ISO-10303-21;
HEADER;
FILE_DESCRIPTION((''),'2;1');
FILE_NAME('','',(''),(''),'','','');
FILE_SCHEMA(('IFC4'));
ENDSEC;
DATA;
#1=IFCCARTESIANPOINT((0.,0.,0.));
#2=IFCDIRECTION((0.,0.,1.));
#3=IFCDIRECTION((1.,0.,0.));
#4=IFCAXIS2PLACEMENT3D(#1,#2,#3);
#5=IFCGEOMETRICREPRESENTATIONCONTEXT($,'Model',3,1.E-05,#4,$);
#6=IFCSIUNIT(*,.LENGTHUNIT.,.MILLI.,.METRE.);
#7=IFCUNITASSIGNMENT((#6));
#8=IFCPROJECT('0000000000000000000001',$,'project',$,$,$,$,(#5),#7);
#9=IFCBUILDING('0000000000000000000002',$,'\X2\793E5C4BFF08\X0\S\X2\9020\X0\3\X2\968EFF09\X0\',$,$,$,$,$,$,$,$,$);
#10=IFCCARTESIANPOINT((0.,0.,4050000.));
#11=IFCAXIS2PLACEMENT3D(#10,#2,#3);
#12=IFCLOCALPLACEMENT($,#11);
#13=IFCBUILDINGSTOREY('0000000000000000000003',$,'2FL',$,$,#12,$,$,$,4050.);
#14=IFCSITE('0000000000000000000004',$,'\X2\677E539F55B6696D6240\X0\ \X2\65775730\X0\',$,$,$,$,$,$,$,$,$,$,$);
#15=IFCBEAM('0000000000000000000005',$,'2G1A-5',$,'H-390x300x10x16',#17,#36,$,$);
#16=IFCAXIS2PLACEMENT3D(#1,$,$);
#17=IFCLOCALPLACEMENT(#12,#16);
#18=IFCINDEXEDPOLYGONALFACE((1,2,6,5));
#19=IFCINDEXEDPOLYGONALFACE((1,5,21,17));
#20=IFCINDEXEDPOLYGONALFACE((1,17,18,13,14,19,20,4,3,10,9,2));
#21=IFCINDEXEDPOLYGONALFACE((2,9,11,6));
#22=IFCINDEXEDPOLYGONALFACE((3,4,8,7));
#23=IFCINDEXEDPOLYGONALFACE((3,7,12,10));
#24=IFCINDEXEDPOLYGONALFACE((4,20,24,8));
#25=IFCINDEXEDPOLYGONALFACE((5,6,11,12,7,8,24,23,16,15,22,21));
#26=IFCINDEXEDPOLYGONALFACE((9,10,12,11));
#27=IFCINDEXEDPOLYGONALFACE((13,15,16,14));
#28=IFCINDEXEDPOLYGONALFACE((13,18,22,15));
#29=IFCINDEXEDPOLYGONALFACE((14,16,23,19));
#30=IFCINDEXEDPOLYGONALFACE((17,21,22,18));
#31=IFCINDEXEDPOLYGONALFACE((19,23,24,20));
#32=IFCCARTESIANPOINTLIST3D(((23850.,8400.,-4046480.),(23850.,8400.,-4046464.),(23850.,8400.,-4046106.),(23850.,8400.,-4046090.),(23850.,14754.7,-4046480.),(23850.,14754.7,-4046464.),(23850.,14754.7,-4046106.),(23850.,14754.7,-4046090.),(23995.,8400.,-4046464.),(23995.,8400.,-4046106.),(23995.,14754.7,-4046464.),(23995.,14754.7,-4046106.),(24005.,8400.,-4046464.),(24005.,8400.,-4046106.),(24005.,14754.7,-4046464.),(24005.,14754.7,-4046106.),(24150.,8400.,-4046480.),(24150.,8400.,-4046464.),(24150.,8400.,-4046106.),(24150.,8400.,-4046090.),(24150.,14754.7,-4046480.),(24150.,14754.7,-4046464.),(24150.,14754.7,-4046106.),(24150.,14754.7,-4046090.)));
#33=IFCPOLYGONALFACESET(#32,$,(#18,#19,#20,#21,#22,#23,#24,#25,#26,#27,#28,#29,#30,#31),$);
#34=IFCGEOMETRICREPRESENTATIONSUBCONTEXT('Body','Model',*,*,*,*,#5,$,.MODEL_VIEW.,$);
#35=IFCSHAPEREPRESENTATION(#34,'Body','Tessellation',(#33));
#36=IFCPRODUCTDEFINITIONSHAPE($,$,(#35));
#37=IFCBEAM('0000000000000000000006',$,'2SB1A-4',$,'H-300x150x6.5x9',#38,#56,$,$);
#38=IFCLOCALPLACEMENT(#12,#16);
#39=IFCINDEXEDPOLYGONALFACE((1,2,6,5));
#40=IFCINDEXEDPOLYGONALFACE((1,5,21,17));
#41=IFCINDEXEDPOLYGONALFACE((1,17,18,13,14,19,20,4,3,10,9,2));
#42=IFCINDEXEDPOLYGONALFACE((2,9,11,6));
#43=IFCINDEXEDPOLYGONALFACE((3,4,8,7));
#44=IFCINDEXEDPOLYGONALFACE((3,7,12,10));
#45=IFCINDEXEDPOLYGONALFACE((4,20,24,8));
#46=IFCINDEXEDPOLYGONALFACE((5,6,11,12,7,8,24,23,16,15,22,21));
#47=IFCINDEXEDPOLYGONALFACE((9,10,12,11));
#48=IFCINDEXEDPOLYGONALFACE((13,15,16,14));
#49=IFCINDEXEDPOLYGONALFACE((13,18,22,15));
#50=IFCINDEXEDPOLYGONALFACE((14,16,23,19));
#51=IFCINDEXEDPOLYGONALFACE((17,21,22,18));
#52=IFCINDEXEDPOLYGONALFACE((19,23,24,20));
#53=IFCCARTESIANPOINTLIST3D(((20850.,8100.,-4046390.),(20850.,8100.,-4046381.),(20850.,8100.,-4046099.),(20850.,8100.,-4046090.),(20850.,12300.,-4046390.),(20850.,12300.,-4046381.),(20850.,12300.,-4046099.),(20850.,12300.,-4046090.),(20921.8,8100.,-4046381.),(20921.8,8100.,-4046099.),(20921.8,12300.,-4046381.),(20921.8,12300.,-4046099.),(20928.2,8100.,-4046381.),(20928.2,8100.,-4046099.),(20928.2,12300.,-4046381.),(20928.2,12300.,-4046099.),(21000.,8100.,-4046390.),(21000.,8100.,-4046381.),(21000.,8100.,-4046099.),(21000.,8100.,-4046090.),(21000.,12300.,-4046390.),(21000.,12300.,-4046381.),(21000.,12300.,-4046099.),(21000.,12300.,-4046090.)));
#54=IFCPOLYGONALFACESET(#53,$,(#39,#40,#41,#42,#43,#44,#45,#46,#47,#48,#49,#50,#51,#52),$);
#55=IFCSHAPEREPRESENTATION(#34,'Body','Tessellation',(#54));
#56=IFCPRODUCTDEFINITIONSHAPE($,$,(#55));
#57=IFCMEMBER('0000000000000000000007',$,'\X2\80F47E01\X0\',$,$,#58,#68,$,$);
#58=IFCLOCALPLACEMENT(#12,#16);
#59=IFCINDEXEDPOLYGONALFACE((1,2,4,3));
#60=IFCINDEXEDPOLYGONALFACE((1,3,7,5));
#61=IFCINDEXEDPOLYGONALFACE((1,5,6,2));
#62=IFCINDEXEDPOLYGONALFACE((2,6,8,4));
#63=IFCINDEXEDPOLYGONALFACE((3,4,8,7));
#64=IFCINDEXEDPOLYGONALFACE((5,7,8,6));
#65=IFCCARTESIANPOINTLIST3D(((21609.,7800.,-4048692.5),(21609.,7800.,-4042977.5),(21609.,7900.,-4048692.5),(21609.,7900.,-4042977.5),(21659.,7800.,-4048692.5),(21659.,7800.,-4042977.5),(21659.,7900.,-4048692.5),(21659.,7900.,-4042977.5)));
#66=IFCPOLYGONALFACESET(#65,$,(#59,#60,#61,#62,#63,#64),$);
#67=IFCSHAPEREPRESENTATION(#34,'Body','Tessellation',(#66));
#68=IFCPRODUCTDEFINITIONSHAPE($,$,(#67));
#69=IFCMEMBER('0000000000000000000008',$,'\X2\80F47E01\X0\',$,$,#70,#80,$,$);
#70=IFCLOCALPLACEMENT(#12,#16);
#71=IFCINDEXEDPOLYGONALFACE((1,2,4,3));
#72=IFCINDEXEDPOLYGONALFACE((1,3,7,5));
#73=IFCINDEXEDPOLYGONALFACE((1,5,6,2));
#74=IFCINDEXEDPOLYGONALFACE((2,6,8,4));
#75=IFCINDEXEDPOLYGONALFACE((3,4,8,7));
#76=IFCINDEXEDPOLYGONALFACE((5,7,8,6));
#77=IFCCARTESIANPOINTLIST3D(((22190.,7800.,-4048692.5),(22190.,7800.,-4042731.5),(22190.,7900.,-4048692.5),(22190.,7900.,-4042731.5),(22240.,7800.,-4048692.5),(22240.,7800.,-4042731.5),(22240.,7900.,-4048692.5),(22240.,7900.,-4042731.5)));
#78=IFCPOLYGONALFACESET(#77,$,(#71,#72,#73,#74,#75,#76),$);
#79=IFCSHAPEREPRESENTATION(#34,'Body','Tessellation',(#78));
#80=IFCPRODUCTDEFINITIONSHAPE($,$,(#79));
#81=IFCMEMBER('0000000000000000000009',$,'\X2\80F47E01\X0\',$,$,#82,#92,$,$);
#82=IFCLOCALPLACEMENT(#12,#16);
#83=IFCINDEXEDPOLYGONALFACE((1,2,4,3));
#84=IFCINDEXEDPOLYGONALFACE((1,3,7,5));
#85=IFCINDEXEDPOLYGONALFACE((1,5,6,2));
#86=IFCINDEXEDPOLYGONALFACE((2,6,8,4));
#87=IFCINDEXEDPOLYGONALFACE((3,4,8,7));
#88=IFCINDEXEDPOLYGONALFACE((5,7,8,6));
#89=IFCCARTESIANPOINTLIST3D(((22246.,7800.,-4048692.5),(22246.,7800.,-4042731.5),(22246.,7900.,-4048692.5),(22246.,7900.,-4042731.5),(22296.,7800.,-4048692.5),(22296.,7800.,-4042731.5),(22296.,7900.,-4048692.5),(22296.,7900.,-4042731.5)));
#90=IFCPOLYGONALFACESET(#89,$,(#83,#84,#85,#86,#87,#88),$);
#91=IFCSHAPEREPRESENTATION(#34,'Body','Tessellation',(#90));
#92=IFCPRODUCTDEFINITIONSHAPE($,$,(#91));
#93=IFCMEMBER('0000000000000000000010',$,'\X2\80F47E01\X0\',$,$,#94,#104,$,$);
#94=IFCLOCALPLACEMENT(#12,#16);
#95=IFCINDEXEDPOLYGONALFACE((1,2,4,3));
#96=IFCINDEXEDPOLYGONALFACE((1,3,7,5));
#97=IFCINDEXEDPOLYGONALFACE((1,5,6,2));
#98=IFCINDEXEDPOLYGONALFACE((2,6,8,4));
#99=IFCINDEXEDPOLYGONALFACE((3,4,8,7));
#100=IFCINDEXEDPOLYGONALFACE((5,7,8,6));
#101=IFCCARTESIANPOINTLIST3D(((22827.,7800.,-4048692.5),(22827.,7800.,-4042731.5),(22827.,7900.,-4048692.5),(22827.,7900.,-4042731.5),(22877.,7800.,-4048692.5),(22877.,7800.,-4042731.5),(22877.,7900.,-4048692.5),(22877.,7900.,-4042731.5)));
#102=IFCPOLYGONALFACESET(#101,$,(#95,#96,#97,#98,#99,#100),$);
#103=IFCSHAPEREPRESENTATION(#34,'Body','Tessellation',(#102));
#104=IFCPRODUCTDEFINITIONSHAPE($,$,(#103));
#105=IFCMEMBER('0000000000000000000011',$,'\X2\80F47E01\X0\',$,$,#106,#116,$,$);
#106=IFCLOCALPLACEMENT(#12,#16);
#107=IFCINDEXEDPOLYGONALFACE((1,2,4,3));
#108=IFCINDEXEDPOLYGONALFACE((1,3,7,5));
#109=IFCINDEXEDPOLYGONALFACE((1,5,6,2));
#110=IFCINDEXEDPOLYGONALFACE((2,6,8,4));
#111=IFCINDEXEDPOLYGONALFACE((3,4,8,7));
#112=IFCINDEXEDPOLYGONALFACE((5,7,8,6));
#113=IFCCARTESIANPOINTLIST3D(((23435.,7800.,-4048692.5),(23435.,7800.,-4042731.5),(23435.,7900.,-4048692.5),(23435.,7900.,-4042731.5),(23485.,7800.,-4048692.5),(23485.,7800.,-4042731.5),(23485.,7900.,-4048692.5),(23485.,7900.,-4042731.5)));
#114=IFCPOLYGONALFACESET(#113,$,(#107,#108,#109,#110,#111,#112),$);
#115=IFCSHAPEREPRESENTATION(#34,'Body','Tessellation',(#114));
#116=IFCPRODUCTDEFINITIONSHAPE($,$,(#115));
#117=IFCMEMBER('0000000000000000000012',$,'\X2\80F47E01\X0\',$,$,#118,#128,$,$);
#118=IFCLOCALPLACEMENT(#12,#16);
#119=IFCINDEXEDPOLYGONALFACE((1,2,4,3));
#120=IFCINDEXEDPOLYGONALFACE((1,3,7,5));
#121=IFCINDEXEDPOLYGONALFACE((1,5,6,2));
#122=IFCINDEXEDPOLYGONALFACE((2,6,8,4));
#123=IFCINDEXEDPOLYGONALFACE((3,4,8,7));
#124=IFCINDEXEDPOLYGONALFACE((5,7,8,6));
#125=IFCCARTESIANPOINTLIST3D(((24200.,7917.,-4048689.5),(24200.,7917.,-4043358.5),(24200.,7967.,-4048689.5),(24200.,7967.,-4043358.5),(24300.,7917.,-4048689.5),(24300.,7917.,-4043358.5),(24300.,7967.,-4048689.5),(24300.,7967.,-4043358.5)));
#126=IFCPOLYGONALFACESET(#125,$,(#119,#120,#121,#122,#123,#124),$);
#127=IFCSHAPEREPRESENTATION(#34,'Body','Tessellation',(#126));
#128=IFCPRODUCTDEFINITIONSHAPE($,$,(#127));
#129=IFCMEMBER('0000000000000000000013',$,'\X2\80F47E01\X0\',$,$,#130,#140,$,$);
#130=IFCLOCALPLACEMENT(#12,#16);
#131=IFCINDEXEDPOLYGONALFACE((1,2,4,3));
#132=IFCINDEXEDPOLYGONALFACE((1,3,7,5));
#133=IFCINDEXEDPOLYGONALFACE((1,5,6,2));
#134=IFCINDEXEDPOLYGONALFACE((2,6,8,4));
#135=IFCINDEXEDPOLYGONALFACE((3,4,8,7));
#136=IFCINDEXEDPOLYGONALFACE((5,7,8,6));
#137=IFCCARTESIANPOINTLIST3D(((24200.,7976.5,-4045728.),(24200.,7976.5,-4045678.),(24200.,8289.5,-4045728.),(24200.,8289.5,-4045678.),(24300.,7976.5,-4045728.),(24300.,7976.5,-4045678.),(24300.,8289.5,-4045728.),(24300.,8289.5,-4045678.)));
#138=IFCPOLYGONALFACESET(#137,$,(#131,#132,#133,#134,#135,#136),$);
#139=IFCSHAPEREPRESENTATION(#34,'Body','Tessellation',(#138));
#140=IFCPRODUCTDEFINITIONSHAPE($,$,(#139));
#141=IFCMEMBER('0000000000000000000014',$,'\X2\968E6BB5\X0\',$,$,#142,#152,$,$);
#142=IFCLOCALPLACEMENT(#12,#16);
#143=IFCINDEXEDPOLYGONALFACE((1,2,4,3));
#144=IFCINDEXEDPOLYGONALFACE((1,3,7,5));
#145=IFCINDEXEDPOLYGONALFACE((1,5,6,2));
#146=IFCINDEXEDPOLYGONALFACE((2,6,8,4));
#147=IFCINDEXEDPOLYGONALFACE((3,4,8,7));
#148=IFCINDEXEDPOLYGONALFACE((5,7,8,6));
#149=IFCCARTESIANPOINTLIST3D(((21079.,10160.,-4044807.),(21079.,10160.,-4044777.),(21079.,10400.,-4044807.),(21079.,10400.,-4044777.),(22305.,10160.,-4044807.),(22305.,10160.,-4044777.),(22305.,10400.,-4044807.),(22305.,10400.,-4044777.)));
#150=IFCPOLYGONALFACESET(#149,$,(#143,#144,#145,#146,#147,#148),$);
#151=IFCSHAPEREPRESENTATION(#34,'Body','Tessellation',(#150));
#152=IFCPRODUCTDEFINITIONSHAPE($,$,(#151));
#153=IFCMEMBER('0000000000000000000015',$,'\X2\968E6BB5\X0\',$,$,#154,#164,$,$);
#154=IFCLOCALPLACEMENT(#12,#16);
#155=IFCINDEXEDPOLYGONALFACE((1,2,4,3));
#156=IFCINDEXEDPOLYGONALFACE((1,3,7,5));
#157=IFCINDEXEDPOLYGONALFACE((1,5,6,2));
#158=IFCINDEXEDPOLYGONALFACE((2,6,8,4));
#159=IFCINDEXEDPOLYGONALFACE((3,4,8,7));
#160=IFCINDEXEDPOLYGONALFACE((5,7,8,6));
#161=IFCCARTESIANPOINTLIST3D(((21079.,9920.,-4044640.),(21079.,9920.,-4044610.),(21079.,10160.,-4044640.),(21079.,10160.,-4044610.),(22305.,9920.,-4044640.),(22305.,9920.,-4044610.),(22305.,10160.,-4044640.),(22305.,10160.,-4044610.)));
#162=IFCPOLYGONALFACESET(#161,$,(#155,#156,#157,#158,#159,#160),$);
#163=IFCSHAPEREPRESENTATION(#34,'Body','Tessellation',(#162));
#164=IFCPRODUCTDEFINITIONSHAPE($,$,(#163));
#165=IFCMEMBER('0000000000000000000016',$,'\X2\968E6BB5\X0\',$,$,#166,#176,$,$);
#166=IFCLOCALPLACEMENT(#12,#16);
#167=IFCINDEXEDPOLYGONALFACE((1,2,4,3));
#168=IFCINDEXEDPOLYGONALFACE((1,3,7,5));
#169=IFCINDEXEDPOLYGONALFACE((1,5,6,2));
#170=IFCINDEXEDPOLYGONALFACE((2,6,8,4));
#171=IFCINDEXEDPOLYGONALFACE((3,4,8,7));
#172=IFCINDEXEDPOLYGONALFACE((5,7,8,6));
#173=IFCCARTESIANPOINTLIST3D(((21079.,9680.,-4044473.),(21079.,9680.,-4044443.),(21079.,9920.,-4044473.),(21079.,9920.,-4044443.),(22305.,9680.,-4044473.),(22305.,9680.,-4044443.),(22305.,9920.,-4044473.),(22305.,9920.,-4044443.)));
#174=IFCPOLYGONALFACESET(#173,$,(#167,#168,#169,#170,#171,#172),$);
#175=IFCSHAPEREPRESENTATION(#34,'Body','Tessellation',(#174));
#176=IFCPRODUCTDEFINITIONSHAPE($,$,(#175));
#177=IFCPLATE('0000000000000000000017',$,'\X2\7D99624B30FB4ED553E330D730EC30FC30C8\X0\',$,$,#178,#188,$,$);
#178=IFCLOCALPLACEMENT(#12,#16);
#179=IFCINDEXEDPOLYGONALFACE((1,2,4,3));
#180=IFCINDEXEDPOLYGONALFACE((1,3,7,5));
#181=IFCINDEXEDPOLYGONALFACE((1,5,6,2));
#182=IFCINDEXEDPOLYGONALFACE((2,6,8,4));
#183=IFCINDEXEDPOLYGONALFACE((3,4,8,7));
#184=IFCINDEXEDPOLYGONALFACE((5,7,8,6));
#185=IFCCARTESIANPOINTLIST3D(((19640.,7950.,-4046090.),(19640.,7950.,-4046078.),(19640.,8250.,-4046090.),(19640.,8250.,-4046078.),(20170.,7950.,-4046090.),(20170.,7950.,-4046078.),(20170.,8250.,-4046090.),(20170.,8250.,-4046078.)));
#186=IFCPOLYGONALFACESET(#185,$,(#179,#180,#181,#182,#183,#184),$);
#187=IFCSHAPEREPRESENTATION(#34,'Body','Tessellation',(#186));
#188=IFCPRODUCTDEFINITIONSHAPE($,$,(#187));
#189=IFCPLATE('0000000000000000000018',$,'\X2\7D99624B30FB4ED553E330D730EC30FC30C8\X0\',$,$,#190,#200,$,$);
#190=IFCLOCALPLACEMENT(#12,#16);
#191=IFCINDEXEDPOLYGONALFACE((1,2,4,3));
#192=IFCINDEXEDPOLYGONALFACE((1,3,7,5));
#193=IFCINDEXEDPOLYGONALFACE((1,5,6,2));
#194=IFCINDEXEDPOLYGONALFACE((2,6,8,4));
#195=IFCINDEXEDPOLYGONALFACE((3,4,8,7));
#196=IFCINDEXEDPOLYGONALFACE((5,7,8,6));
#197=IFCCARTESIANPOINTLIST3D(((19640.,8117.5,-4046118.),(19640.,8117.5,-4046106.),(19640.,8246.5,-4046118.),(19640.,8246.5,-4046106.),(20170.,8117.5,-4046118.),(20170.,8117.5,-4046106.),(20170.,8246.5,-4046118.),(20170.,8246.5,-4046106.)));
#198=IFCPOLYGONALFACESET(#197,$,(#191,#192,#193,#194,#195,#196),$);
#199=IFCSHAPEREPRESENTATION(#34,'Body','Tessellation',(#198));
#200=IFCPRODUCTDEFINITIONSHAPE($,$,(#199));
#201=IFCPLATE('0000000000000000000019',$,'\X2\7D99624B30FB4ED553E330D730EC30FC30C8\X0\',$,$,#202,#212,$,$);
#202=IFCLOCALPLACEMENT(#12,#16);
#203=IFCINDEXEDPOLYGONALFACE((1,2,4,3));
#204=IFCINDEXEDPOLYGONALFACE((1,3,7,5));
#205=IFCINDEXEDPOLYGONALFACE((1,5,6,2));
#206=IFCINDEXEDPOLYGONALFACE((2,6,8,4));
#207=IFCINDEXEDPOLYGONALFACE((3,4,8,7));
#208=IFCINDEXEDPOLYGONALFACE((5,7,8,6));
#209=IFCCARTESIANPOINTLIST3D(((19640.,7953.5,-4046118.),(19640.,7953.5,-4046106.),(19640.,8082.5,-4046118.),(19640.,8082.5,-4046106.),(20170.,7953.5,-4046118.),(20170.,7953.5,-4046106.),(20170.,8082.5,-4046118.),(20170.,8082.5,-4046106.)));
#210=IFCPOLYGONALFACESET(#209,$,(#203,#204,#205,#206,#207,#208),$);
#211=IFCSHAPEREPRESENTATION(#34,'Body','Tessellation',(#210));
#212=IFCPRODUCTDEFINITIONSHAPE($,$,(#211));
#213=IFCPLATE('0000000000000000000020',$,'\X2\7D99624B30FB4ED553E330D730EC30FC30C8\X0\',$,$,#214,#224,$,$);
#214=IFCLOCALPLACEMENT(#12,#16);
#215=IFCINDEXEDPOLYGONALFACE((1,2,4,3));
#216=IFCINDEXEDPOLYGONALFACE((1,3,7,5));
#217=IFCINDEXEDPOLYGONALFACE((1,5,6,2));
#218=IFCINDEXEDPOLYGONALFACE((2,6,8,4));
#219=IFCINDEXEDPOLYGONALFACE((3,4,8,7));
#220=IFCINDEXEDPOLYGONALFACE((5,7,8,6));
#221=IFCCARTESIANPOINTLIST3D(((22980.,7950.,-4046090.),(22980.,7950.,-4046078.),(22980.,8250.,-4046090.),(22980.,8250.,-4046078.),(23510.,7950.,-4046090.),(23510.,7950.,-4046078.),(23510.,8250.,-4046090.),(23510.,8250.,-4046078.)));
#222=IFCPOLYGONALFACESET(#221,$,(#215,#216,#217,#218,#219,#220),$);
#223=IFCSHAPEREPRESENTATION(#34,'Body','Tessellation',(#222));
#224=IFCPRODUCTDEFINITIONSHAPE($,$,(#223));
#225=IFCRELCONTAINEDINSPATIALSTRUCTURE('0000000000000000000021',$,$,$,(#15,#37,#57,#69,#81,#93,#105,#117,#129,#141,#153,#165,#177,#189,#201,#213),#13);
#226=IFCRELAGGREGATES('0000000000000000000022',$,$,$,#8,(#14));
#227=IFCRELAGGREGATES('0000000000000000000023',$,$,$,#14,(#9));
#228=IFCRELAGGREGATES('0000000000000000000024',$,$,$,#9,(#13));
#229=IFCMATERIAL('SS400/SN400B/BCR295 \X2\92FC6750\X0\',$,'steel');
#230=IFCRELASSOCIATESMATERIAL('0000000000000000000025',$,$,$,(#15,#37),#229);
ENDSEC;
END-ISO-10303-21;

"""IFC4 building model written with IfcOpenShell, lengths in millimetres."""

from ifc_helpers import new_model, si_unit, frame, origin, origin_with_axes, place, context, subcontext, project, spatial, rectangle, i_section, extrude, material, element, save


model = new_model("IFC4")

# Units and contexts
model_context = context("Model", 3, precision=1e-05, world=origin_with_axes())
body_context = subcontext(model_context, "Body", "Model", "MODEL_VIEW")
ifc_project = project(units=[si_unit("LENGTHUNIT", "METRE", prefix="MILLI")], contexts=[model_context])

# Site, building, storey
site = spatial("IfcSite", under=ifc_project, Name="松原営業所 敷地")
building = spatial("IfcBuilding", under=site, Name="社屋（S造3階）")
storey_placement = place(None, frame((0.0, 0.0, 4050000.0), z_axis=(0.0, 0.0, 1.0), x_axis=(1.0, 0.0, 0.0)))
storey = spatial("IfcBuildingStorey", under=building, at=storey_placement, Name="2FL", Elevation=4050.0)

# Beams
ifc_material = material(Name="SS400/SN400B/BCR295 鋼材", Category="steel")
beam_1_placement = place(storey_placement, frame((24000.0, 8400.0, -4046090.0), z_axis=(0.0, 1.0, 0.0), x_axis=(-1.0, 0.0, 0.0)))
element("IfcBeam", 1, at=beam_1_placement, inside=storey, material=ifc_material, Name="2G1A-5", ObjectType="H-390x300x10x16", context=body_context, shape_type="SweptSolid", body=[
    extrude(i_section(OverallWidth=300.0, OverallDepth=390.0, WebThickness=10.0, FlangeThickness=16.0), frame((0.0, -195.0, 0.0)), (0.0, 0.0, 1.0), 6354.7),
])
beam_2_placement = place(storey_placement, frame((20925.0, 8100.0, -4046090.0), z_axis=(0.0, 1.0, 0.0), x_axis=(-1.0, 0.0, 0.0)))
element("IfcBeam", 2, at=beam_2_placement, inside=storey, material=ifc_material, Name="2SB1A-4", ObjectType="H-300x150x6.5x9", context=body_context, shape_type="SweptSolid", body=[
    extrude(i_section(OverallWidth=150.0, OverallDepth=300.0, WebThickness=6.5, FlangeThickness=9.0), frame((0.0, -150.0, 0.0)), (0.0, 0.0, 1.0), 4200.0),
])

# Members
member_1_placement = place(storey_placement, frame((21609.0, 7850.0, -4045835.0), z_axis=(1.0, 0.0, 0.0), x_axis=(0.0, 1.0, 0.0)))
element("IfcMember", 3, at=member_1_placement, inside=storey, Name="胴縁", context=body_context, shape_type="SweptSolid", body=[
    extrude(rectangle(XDim=100.0, YDim=5715.0), origin(), (0.0, 0.0, 1.0), 50.0),
])
for number, where, z_axis, x_axis, name in (
    (4, (22190.0, 7850.0, -4045712.0), (1.0, 0.0, 0.0), (0.0, 1.0, 0.0), "胴縁"),
    (5, (22246.0, 7850.0, -4045712.0), (1.0, 0.0, 0.0), (0.0, 1.0, 0.0), "胴縁"),
    (6, (22827.0, 7850.0, -4045712.0), (1.0, 0.0, 0.0), (0.0, 1.0, 0.0), "胴縁"),
    (7, (23435.0, 7850.0, -4045712.0), (1.0, 0.0, 0.0), (0.0, 1.0, 0.0), "胴縁"),
):
    element("IfcMember", number, at=place(storey_placement, frame(where, z_axis=z_axis, x_axis=x_axis)), inside=storey, Name=name, context=body_context, shape_type="SweptSolid", body=[
        extrude(rectangle(XDim=100.0, YDim=5961.0), origin(), (0.0, 0.0, 1.0), 50.0),
    ])
member_2_placement = place(storey_placement, frame((24250.0, 7917.0, -4046024.0), z_axis=(0.0, 1.0, 0.0), x_axis=(-1.0, 0.0, 0.0)))
element("IfcMember", 8, at=member_2_placement, inside=storey, Name="胴縁", context=body_context, shape_type="SweptSolid", body=[
    extrude(rectangle(XDim=100.0, YDim=5331.0), origin(), (0.0, 0.0, 1.0), 50.0),
])
member_3_placement = place(storey_placement, frame((24250.0, 7976.5, -4045703.0), z_axis=(0.0, 1.0, 0.0), x_axis=(-1.0, 0.0, 0.0)))
element("IfcMember", 9, at=member_3_placement, inside=storey, Name="胴縁", context=body_context, shape_type="SweptSolid", body=[
    extrude(rectangle(XDim=100.0, YDim=50.0), origin(), (0.0, 0.0, 1.0), 313.0),
])
for number, where, z_axis, x_axis, name in (
    (10, (21692.0, 10160.0, -4044792.0), (0.0, 1.0, 0.0), (-1.0, 0.0, 0.0), "階段"),
    (11, (21692.0, 9920.0, -4044625.0), (0.0, 1.0, 0.0), (-1.0, 0.0, 0.0), "階段"),
    (12, (21692.0, 9680.0, -4044458.0), (0.0, 1.0, 0.0), (-1.0, 0.0, 0.0), "階段"),
):
    element("IfcMember", number, at=place(storey_placement, frame(where, z_axis=z_axis, x_axis=x_axis)), inside=storey, Name=name, context=body_context, shape_type="SweptSolid", body=[
        extrude(rectangle(XDim=1226.0, YDim=30.0), origin(), (0.0, 0.0, 1.0), 240.0),
    ])

# Plates
plate_1_placement = place(storey_placement, frame((19640.0, 8100.0, -4046084.0), z_axis=(1.0, 0.0, 0.0), x_axis=(0.0, 1.0, 0.0)))
element("IfcPlate", 13, at=plate_1_placement, inside=storey, Name="継手・仕口プレート", context=body_context, shape_type="SweptSolid", body=[
    extrude(rectangle(XDim=300.0, YDim=12.0), origin(), (0.0, 0.0, 1.0), 530.0),
])
for number, where, z_axis, x_axis, name in (
    (14, (19640.0, 8182.0, -4046112.0), (1.0, 0.0, 0.0), (0.0, 1.0, 0.0), "継手・仕口プレート"),
    (15, (19640.0, 8018.0, -4046112.0), (1.0, 0.0, 0.0), (0.0, 1.0, 0.0), "継手・仕口プレート"),
):
    element("IfcPlate", number, at=place(storey_placement, frame(where, z_axis=z_axis, x_axis=x_axis)), inside=storey, Name=name, context=body_context, shape_type="SweptSolid", body=[
        extrude(rectangle(XDim=129.0, YDim=12.0), origin(), (0.0, 0.0, 1.0), 530.0),
    ])
plate_2_placement = place(storey_placement, frame((22980.0, 8100.0, -4046084.0), z_axis=(1.0, 0.0, 0.0), x_axis=(0.0, 1.0, 0.0)))
element("IfcPlate", 16, at=plate_2_placement, inside=storey, Name="継手・仕口プレート", context=body_context, shape_type="SweptSolid", body=[
    extrude(rectangle(XDim=300.0, YDim=12.0), origin(), (0.0, 0.0, 1.0), 530.0),
])

save(model, "model.ifc")
